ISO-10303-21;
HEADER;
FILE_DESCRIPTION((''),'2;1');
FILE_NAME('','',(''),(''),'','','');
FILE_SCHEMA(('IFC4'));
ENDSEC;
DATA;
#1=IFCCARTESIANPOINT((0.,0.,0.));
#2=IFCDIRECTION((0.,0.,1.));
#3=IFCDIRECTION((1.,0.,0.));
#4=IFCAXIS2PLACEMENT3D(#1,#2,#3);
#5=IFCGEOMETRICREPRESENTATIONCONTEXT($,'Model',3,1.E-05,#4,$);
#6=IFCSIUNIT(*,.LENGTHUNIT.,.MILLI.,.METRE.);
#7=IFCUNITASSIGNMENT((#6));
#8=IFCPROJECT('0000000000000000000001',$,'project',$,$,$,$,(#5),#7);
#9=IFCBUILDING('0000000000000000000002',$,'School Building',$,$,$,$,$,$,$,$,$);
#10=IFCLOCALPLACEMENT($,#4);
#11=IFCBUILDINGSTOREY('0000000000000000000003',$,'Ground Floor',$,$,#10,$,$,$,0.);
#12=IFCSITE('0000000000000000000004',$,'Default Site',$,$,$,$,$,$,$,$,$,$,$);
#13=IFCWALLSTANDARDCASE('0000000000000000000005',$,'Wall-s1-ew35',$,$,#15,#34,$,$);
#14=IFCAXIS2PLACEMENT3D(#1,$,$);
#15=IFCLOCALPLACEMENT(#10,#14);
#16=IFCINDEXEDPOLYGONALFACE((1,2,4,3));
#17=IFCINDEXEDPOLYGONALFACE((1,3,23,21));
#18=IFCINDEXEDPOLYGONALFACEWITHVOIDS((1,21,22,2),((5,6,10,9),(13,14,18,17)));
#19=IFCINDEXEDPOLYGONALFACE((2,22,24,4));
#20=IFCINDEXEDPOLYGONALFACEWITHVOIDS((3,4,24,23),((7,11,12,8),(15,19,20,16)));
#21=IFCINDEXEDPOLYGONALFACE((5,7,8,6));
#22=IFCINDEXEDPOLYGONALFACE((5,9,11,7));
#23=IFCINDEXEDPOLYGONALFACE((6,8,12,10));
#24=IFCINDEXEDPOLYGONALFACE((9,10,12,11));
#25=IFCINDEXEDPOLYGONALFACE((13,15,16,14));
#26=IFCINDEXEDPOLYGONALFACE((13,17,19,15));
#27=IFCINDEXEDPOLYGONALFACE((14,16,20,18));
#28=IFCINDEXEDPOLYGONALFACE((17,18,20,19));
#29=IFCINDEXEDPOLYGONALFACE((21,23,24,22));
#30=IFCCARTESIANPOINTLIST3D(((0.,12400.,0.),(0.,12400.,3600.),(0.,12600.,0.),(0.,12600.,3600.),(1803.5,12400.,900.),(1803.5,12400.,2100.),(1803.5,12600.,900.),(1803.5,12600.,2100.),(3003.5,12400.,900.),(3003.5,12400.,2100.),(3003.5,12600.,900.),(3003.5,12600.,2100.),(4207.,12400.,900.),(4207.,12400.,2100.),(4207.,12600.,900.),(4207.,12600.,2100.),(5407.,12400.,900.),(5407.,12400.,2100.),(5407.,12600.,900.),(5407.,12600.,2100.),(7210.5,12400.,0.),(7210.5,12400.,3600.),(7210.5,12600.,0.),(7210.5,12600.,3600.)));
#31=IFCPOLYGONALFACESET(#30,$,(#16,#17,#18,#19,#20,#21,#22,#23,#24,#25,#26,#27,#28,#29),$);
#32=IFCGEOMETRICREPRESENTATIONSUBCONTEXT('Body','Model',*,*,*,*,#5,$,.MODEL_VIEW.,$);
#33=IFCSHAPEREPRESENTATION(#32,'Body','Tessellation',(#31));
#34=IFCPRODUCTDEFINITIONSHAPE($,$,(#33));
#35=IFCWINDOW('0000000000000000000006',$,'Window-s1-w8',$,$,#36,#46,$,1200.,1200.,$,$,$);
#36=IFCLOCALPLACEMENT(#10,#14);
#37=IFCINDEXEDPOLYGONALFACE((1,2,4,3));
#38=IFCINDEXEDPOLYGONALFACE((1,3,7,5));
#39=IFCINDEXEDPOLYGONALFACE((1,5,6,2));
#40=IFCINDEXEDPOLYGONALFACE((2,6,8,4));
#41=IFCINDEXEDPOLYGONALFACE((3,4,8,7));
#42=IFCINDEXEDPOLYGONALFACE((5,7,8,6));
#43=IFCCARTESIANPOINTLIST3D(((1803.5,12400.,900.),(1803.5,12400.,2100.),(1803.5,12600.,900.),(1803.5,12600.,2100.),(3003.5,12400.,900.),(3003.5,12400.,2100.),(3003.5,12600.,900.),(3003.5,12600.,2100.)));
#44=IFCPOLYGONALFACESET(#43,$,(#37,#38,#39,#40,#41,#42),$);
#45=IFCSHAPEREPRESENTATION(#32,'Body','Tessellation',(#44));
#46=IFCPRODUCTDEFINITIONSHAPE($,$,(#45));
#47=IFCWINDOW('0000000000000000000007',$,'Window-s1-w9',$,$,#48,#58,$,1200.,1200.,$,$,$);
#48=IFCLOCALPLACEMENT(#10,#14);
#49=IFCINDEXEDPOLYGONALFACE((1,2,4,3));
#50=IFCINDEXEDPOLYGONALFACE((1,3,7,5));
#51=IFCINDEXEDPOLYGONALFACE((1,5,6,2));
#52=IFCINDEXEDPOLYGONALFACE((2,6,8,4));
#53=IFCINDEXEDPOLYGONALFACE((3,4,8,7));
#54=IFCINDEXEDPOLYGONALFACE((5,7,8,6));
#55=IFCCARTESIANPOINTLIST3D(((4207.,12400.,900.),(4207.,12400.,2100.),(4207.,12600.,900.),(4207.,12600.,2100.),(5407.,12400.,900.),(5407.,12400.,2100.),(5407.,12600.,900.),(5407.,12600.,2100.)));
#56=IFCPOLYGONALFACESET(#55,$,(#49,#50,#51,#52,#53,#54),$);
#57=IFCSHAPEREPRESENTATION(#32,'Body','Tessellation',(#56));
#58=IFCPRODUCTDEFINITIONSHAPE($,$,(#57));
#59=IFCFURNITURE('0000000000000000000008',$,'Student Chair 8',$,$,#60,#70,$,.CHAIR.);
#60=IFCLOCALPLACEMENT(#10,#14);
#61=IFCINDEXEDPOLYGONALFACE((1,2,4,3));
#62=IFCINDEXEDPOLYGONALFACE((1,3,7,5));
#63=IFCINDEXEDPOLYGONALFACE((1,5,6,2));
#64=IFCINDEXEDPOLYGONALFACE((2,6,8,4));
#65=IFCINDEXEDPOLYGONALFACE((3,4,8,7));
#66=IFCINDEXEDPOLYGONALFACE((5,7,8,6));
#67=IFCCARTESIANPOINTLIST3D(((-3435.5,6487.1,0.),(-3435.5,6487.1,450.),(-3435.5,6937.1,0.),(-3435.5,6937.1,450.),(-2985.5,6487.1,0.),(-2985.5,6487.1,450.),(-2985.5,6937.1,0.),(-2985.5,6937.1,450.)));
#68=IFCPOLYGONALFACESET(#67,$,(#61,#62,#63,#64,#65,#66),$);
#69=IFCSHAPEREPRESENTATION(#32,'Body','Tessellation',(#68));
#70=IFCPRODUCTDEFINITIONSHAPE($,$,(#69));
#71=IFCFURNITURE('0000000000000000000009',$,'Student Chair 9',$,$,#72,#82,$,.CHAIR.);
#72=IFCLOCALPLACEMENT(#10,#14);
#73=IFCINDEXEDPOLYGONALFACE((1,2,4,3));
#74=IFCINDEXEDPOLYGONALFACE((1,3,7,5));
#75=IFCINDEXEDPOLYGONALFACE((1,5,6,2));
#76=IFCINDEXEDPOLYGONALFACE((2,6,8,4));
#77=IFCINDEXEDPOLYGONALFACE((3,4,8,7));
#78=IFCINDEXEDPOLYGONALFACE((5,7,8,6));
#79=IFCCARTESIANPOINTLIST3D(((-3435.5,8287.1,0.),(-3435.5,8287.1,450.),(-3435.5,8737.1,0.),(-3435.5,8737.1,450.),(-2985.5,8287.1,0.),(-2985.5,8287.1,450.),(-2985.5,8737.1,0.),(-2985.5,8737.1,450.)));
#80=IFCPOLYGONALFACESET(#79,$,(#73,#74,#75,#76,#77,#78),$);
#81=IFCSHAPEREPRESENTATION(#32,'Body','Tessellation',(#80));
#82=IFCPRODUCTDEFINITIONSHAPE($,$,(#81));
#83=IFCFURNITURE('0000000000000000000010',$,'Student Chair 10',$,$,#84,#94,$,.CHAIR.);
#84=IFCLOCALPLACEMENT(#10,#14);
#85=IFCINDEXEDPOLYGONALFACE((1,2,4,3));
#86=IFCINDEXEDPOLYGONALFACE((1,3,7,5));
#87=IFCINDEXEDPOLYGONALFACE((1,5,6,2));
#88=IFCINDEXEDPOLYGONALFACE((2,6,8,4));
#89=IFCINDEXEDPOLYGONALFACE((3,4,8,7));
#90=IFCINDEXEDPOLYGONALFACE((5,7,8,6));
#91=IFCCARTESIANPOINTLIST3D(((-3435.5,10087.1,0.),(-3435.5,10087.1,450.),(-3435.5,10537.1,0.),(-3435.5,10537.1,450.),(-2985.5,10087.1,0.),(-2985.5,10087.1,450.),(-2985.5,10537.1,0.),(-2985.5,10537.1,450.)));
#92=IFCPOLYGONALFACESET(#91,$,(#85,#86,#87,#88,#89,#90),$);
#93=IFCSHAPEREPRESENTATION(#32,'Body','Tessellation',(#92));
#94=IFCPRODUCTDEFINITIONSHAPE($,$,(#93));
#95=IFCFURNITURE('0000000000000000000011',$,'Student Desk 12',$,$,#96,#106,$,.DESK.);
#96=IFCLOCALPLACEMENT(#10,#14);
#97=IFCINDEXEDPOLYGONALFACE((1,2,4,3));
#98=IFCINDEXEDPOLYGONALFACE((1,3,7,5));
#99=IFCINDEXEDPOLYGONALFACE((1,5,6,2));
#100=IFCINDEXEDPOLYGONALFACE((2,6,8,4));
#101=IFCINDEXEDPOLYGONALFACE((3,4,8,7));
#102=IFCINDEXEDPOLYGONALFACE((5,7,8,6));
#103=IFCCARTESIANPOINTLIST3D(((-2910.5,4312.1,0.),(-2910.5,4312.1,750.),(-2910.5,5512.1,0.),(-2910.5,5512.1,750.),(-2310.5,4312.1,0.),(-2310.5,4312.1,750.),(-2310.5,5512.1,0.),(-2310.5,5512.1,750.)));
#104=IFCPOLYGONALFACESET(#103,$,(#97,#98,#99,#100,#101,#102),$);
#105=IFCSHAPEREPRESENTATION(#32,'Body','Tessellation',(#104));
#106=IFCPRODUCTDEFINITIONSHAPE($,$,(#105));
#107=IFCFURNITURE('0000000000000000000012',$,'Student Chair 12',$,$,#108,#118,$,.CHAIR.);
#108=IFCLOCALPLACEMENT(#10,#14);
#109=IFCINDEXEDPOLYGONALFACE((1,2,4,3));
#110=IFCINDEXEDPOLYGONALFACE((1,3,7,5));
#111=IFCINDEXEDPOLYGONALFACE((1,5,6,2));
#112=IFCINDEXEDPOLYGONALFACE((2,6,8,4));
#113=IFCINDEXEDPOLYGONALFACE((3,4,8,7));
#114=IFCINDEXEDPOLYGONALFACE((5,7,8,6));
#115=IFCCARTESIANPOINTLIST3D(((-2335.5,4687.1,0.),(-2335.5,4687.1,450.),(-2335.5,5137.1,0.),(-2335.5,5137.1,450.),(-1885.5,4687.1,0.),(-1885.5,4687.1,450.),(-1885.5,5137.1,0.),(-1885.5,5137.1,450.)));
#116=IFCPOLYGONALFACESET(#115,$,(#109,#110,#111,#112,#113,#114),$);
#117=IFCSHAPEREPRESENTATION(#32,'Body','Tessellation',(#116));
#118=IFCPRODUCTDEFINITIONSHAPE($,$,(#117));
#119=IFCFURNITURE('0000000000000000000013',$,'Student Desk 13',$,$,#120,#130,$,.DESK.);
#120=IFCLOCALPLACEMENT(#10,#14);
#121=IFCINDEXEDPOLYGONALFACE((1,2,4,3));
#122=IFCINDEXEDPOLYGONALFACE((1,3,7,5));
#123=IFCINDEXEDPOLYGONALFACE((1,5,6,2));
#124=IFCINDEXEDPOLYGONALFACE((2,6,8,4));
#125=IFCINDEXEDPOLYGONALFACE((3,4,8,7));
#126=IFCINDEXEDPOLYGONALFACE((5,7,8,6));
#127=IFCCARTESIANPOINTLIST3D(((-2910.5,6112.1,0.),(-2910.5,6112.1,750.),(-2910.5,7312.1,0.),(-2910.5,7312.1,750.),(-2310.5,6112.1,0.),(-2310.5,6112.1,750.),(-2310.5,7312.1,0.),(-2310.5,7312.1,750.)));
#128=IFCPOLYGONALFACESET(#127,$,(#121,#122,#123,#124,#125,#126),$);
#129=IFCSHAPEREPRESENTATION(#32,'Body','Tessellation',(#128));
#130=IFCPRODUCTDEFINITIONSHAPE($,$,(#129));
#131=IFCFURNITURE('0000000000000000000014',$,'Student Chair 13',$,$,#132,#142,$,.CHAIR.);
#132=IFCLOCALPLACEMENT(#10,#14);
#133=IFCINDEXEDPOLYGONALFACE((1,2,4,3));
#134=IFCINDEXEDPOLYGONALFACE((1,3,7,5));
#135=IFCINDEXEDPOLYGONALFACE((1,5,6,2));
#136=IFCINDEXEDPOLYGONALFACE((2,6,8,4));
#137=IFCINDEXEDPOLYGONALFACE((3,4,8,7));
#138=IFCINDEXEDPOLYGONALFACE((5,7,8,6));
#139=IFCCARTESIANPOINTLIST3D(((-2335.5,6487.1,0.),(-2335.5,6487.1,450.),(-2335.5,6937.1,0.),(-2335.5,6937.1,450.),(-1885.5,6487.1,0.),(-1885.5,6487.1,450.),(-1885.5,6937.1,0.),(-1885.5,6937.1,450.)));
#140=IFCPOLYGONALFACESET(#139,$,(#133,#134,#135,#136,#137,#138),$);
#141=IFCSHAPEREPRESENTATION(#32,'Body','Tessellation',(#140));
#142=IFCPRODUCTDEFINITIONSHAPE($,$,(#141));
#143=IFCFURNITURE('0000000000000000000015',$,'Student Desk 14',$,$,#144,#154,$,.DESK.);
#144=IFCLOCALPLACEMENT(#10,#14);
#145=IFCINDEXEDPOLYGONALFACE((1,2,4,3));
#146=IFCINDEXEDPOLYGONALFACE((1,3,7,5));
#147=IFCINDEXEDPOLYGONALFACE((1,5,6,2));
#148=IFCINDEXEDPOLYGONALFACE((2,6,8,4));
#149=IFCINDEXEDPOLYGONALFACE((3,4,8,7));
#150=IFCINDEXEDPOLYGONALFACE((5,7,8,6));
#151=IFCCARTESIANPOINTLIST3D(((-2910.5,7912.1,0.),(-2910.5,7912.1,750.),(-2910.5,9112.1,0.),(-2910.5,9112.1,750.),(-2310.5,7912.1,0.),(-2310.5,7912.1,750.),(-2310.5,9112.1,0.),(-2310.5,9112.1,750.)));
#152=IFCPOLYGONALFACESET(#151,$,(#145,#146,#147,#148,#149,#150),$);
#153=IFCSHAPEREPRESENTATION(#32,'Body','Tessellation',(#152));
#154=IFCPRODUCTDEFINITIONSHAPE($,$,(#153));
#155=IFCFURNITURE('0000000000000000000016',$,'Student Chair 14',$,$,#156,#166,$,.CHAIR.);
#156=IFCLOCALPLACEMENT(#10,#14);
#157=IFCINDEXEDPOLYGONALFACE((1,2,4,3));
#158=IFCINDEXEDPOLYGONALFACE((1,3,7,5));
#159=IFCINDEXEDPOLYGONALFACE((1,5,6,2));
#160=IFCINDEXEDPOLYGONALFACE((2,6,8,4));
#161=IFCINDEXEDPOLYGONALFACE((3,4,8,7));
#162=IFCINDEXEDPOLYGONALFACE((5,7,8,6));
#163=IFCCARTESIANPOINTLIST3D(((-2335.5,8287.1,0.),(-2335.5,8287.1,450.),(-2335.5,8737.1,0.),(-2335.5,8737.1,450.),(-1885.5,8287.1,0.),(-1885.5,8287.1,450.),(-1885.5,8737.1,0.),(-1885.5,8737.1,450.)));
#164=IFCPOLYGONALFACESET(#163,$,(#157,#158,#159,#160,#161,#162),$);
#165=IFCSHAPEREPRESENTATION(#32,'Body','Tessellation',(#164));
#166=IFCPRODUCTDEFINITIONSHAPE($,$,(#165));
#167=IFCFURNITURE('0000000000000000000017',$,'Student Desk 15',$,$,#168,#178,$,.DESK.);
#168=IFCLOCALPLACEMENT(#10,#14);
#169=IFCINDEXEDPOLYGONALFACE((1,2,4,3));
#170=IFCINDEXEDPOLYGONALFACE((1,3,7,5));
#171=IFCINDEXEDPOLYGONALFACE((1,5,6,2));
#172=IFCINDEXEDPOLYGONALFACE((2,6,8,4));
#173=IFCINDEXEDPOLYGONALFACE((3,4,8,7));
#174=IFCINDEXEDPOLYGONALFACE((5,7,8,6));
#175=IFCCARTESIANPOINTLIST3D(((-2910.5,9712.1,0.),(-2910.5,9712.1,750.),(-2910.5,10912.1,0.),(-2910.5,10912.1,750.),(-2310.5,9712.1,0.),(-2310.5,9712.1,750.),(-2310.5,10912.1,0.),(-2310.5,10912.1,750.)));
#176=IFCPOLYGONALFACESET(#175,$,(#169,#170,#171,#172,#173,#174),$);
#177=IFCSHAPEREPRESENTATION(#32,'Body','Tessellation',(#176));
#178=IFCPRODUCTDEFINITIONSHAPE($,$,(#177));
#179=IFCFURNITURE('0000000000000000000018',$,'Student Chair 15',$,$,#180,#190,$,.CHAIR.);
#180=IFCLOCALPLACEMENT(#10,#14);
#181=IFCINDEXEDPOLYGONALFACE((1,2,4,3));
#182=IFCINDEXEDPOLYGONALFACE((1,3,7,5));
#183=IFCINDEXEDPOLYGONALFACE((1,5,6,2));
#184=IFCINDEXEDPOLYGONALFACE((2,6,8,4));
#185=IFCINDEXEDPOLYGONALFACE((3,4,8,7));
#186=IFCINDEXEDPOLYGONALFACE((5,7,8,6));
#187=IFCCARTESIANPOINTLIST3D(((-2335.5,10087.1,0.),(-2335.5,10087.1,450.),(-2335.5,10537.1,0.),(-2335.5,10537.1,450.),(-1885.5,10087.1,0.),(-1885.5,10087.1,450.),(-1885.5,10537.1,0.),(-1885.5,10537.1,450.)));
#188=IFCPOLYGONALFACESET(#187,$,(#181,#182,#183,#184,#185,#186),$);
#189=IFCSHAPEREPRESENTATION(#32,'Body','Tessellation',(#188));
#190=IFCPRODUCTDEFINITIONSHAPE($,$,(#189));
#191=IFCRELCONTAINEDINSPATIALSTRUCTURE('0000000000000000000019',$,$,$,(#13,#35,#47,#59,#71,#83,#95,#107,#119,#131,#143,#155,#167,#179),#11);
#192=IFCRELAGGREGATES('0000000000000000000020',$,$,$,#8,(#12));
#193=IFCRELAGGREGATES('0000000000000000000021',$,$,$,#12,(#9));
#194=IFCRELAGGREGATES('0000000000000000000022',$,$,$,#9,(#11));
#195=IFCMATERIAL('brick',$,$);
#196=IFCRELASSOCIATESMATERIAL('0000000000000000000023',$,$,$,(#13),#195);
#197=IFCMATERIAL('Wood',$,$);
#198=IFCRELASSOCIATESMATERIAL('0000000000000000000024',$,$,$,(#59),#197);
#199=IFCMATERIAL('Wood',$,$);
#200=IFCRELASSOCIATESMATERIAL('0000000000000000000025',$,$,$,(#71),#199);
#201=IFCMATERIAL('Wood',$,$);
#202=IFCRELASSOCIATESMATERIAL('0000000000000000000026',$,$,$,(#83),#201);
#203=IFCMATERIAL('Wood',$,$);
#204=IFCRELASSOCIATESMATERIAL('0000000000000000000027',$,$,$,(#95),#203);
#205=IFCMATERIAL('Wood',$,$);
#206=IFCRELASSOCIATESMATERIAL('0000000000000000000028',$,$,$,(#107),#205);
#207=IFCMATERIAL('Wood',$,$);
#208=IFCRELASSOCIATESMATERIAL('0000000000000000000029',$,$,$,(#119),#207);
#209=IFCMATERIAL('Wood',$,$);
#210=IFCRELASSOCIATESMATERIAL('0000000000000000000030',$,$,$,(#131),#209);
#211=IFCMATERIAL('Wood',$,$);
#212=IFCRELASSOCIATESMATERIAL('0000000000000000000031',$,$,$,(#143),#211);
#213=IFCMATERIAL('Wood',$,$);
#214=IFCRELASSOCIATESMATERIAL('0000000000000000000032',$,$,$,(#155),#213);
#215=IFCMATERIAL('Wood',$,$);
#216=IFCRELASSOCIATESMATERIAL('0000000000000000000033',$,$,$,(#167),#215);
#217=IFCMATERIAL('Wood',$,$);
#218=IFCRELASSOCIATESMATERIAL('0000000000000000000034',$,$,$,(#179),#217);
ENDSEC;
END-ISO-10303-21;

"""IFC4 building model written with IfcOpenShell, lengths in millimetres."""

from ifc_helpers import new_model, si_unit, frame, frame_2d, origin_with_axes, origin_2d, place, context, subcontext, project, spatial, rectangle, extrude, material, element, fill, save


model = new_model("IFC4")

# Units and contexts
model_context = context("Model", 3, precision=1e-05, world=origin_with_axes())
body_context = subcontext(model_context, "Body", "Model", "MODEL_VIEW")
ifc_project = project(units=[si_unit("LENGTHUNIT", "METRE", prefix="MILLI")], contexts=[model_context])

# Site, building, storey
site = spatial("IfcSite", under=ifc_project, Name="Default Site")
building = spatial("IfcBuilding", under=site, Name="School Building")
storey_placement = place(None, origin_with_axes())
storey = spatial("IfcBuildingStorey", under=building, at=storey_placement, Name="Ground Floor", Elevation=0.0)

# Wall, openings, windows
ifc_material_1 = material(Name="brick")
wall_placement = place(storey_placement, frame((0.0, 12500.0, 0.0), z_axis=(0.0, 0.0, 1.0), x_axis=(1.0, 0.0, 0.0)))
wall = element("IfcWallStandardCase", 1, at=wall_placement, inside=storey, material=ifc_material_1, Name="Wall-s1-ew35", context=body_context, shape_type="SweptSolid", body=[
    extrude(rectangle(XDim=7210.5, YDim=200.0, at=frame_2d((3605.2, 0.0))), origin_with_axes(), (0.0, 0.0, 1.0), 3600.0),
])
opening_1_placement = place(wall_placement, frame((1803.5, 0.0, 900.0), z_axis=(0.0, 0.0, 1.0), x_axis=(1.0, 0.0, 0.0)))
opening_1 = element("IfcOpeningElement", 2, at=opening_1_placement, cuts=wall, context=body_context, shape_type="SweptSolid", body=[
    extrude(rectangle(XDim=1200.0, YDim=400.0, at=frame_2d((600.0, 0.0))), origin_with_axes(), (0.0, 0.0, 1.0), 1200.0),
])
opening_2_placement = place(wall_placement, frame((4207.0, 0.0, 900.0), z_axis=(0.0, 0.0, 1.0), x_axis=(1.0, 0.0, 0.0)))
opening_2 = element("IfcOpeningElement", 3, at=opening_2_placement, cuts=wall, context=body_context, shape_type="SweptSolid", body=[
    extrude(rectangle(XDim=1200.0, YDim=400.0, at=frame_2d((600.0, 0.0))), origin_with_axes(), (0.0, 0.0, 1.0), 1200.0),
])
window_1_placement = place(storey_placement, frame((1803.5, 12500.0, 900.0), z_axis=(0.0, 0.0, 1.0), x_axis=(1.0, 0.0, 0.0)))
window_1 = element("IfcWindow", 4, at=window_1_placement, inside=storey, Name="Window-s1-w8", OverallHeight=1200.0, OverallWidth=1200.0, context=body_context, shape_type="SweptSolid", body=[
    extrude(rectangle(XDim=1200.0, YDim=200.0, at=frame_2d((600.0, 0.0))), origin_with_axes(), (0.0, 0.0, 1.0), 1200.0),
])
fill(opening_1, window_1)
window_2_placement = place(storey_placement, frame((4207.0, 12500.0, 900.0), z_axis=(0.0, 0.0, 1.0), x_axis=(1.0, 0.0, 0.0)))
window_2 = element("IfcWindow", 5, at=window_2_placement, inside=storey, Name="Window-s1-w9", OverallHeight=1200.0, OverallWidth=1200.0, context=body_context, shape_type="SweptSolid", body=[
    extrude(rectangle(XDim=1200.0, YDim=200.0, at=frame_2d((600.0, 0.0))), origin_with_axes(), (0.0, 0.0, 1.0), 1200.0),
])
fill(opening_2, window_2)

# Furniture
ifc_material_2 = material(Name="Wood")
furniture_1_placement = place(storey_placement, frame((-3210.5, 6712.1, 0.0), z_axis=(0.0, 0.0, 1.0), x_axis=(1.0, 0.0, 0.0)))
element("IfcFurniture", 6, at=furniture_1_placement, inside=storey, material=ifc_material_2, Name="Student Chair 8", PredefinedType="CHAIR", context=body_context, shape_type="SweptSolid", body=[
    extrude(rectangle(XDim=450.0, YDim=450.0, at=origin_2d()), origin_with_axes(), (0.0, 0.0, 1.0), 450.0),
])
ifc_material_3 = material(Name="Wood")
furniture_2_placement = place(storey_placement, frame((-3210.5, 8512.1, 0.0), z_axis=(0.0, 0.0, 1.0), x_axis=(1.0, 0.0, 0.0)))
element("IfcFurniture", 7, at=furniture_2_placement, inside=storey, material=ifc_material_3, Name="Student Chair 9", PredefinedType="CHAIR", context=body_context, shape_type="SweptSolid", body=[
    extrude(rectangle(XDim=450.0, YDim=450.0, at=origin_2d()), origin_with_axes(), (0.0, 0.0, 1.0), 450.0),
])
ifc_material_4 = material(Name="Wood")
furniture_3_placement = place(storey_placement, frame((-3210.5, 10312.1, 0.0), z_axis=(0.0, 0.0, 1.0), x_axis=(1.0, 0.0, 0.0)))
element("IfcFurniture", 8, at=furniture_3_placement, inside=storey, material=ifc_material_4, Name="Student Chair 10", PredefinedType="CHAIR", context=body_context, shape_type="SweptSolid", body=[
    extrude(rectangle(XDim=450.0, YDim=450.0, at=origin_2d()), origin_with_axes(), (0.0, 0.0, 1.0), 450.0),
])
ifc_material_5 = material(Name="Wood")
furniture_4_placement = place(storey_placement, frame((-2610.5, 4912.1, 0.0), z_axis=(0.0, 0.0, 1.0), x_axis=(0.0, 1.0, 0.0)))
element("IfcFurniture", 9, at=furniture_4_placement, inside=storey, material=ifc_material_5, Name="Student Desk 12", PredefinedType="DESK", context=body_context, shape_type="SweptSolid", body=[
    extrude(rectangle(XDim=1200.0, YDim=600.0, at=origin_2d()), origin_with_axes(), (0.0, 0.0, 1.0), 750.0),
])
ifc_material_6 = material(Name="Wood")
furniture_5_placement = place(storey_placement, frame((-2110.5, 4912.1, 0.0), z_axis=(0.0, 0.0, 1.0), x_axis=(1.0, 0.0, 0.0)))
element("IfcFurniture", 10, at=furniture_5_placement, inside=storey, material=ifc_material_6, Name="Student Chair 12", PredefinedType="CHAIR", context=body_context, shape_type="SweptSolid", body=[
    extrude(rectangle(XDim=450.0, YDim=450.0, at=origin_2d()), origin_with_axes(), (0.0, 0.0, 1.0), 450.0),
])
ifc_material_7 = material(Name="Wood")
furniture_6_placement = place(storey_placement, frame((-2610.5, 6712.1, 0.0), z_axis=(0.0, 0.0, 1.0), x_axis=(0.0, 1.0, 0.0)))
element("IfcFurniture", 11, at=furniture_6_placement, inside=storey, material=ifc_material_7, Name="Student Desk 13", PredefinedType="DESK", context=body_context, shape_type="SweptSolid", body=[
    extrude(rectangle(XDim=1200.0, YDim=600.0, at=origin_2d()), origin_with_axes(), (0.0, 0.0, 1.0), 750.0),
])
ifc_material_8 = material(Name="Wood")
furniture_7_placement = place(storey_placement, frame((-2110.5, 6712.1, 0.0), z_axis=(0.0, 0.0, 1.0), x_axis=(1.0, 0.0, 0.0)))
element("IfcFurniture", 12, at=furniture_7_placement, inside=storey, material=ifc_material_8, Name="Student Chair 13", PredefinedType="CHAIR", context=body_context, shape_type="SweptSolid", body=[
    extrude(rectangle(XDim=450.0, YDim=450.0, at=origin_2d()), origin_with_axes(), (0.0, 0.0, 1.0), 450.0),
])
ifc_material_9 = material(Name="Wood")
furniture_8_placement = place(storey_placement, frame((-2610.5, 8512.1, 0.0), z_axis=(0.0, 0.0, 1.0), x_axis=(0.0, 1.0, 0.0)))
element("IfcFurniture", 13, at=furniture_8_placement, inside=storey, material=ifc_material_9, Name="Student Desk 14", PredefinedType="DESK", context=body_context, shape_type="SweptSolid", body=[
    extrude(rectangle(XDim=1200.0, YDim=600.0, at=origin_2d()), origin_with_axes(), (0.0, 0.0, 1.0), 750.0),
])
ifc_material_10 = material(Name="Wood")
furniture_9_placement = place(storey_placement, frame((-2110.5, 8512.1, 0.0), z_axis=(0.0, 0.0, 1.0), x_axis=(1.0, 0.0, 0.0)))
element("IfcFurniture", 14, at=furniture_9_placement, inside=storey, material=ifc_material_10, Name="Student Chair 14", PredefinedType="CHAIR", context=body_context, shape_type="SweptSolid", body=[
    extrude(rectangle(XDim=450.0, YDim=450.0, at=origin_2d()), origin_with_axes(), (0.0, 0.0, 1.0), 450.0),
])
ifc_material_11 = material(Name="Wood")
furniture_10_placement = place(storey_placement, frame((-2610.5, 10312.1, 0.0), z_axis=(0.0, 0.0, 1.0), x_axis=(0.0, 1.0, 0.0)))
element("IfcFurniture", 15, at=furniture_10_placement, inside=storey, material=ifc_material_11, Name="Student Desk 15", PredefinedType="DESK", context=body_context, shape_type="SweptSolid", body=[
    extrude(rectangle(XDim=1200.0, YDim=600.0, at=origin_2d()), origin_with_axes(), (0.0, 0.0, 1.0), 750.0),
])
ifc_material_12 = material(Name="Wood")
furniture_11_placement = place(storey_placement, frame((-2110.5, 10312.1, 0.0), z_axis=(0.0, 0.0, 1.0), x_axis=(1.0, 0.0, 0.0)))
element("IfcFurniture", 16, at=furniture_11_placement, inside=storey, material=ifc_material_12, Name="Student Chair 15", PredefinedType="CHAIR", context=body_context, shape_type="SweptSolid", body=[
    extrude(rectangle(XDim=450.0, YDim=450.0, at=origin_2d()), origin_with_axes(), (0.0, 0.0, 1.0), 450.0),
])

save(model, "model.ifc")
